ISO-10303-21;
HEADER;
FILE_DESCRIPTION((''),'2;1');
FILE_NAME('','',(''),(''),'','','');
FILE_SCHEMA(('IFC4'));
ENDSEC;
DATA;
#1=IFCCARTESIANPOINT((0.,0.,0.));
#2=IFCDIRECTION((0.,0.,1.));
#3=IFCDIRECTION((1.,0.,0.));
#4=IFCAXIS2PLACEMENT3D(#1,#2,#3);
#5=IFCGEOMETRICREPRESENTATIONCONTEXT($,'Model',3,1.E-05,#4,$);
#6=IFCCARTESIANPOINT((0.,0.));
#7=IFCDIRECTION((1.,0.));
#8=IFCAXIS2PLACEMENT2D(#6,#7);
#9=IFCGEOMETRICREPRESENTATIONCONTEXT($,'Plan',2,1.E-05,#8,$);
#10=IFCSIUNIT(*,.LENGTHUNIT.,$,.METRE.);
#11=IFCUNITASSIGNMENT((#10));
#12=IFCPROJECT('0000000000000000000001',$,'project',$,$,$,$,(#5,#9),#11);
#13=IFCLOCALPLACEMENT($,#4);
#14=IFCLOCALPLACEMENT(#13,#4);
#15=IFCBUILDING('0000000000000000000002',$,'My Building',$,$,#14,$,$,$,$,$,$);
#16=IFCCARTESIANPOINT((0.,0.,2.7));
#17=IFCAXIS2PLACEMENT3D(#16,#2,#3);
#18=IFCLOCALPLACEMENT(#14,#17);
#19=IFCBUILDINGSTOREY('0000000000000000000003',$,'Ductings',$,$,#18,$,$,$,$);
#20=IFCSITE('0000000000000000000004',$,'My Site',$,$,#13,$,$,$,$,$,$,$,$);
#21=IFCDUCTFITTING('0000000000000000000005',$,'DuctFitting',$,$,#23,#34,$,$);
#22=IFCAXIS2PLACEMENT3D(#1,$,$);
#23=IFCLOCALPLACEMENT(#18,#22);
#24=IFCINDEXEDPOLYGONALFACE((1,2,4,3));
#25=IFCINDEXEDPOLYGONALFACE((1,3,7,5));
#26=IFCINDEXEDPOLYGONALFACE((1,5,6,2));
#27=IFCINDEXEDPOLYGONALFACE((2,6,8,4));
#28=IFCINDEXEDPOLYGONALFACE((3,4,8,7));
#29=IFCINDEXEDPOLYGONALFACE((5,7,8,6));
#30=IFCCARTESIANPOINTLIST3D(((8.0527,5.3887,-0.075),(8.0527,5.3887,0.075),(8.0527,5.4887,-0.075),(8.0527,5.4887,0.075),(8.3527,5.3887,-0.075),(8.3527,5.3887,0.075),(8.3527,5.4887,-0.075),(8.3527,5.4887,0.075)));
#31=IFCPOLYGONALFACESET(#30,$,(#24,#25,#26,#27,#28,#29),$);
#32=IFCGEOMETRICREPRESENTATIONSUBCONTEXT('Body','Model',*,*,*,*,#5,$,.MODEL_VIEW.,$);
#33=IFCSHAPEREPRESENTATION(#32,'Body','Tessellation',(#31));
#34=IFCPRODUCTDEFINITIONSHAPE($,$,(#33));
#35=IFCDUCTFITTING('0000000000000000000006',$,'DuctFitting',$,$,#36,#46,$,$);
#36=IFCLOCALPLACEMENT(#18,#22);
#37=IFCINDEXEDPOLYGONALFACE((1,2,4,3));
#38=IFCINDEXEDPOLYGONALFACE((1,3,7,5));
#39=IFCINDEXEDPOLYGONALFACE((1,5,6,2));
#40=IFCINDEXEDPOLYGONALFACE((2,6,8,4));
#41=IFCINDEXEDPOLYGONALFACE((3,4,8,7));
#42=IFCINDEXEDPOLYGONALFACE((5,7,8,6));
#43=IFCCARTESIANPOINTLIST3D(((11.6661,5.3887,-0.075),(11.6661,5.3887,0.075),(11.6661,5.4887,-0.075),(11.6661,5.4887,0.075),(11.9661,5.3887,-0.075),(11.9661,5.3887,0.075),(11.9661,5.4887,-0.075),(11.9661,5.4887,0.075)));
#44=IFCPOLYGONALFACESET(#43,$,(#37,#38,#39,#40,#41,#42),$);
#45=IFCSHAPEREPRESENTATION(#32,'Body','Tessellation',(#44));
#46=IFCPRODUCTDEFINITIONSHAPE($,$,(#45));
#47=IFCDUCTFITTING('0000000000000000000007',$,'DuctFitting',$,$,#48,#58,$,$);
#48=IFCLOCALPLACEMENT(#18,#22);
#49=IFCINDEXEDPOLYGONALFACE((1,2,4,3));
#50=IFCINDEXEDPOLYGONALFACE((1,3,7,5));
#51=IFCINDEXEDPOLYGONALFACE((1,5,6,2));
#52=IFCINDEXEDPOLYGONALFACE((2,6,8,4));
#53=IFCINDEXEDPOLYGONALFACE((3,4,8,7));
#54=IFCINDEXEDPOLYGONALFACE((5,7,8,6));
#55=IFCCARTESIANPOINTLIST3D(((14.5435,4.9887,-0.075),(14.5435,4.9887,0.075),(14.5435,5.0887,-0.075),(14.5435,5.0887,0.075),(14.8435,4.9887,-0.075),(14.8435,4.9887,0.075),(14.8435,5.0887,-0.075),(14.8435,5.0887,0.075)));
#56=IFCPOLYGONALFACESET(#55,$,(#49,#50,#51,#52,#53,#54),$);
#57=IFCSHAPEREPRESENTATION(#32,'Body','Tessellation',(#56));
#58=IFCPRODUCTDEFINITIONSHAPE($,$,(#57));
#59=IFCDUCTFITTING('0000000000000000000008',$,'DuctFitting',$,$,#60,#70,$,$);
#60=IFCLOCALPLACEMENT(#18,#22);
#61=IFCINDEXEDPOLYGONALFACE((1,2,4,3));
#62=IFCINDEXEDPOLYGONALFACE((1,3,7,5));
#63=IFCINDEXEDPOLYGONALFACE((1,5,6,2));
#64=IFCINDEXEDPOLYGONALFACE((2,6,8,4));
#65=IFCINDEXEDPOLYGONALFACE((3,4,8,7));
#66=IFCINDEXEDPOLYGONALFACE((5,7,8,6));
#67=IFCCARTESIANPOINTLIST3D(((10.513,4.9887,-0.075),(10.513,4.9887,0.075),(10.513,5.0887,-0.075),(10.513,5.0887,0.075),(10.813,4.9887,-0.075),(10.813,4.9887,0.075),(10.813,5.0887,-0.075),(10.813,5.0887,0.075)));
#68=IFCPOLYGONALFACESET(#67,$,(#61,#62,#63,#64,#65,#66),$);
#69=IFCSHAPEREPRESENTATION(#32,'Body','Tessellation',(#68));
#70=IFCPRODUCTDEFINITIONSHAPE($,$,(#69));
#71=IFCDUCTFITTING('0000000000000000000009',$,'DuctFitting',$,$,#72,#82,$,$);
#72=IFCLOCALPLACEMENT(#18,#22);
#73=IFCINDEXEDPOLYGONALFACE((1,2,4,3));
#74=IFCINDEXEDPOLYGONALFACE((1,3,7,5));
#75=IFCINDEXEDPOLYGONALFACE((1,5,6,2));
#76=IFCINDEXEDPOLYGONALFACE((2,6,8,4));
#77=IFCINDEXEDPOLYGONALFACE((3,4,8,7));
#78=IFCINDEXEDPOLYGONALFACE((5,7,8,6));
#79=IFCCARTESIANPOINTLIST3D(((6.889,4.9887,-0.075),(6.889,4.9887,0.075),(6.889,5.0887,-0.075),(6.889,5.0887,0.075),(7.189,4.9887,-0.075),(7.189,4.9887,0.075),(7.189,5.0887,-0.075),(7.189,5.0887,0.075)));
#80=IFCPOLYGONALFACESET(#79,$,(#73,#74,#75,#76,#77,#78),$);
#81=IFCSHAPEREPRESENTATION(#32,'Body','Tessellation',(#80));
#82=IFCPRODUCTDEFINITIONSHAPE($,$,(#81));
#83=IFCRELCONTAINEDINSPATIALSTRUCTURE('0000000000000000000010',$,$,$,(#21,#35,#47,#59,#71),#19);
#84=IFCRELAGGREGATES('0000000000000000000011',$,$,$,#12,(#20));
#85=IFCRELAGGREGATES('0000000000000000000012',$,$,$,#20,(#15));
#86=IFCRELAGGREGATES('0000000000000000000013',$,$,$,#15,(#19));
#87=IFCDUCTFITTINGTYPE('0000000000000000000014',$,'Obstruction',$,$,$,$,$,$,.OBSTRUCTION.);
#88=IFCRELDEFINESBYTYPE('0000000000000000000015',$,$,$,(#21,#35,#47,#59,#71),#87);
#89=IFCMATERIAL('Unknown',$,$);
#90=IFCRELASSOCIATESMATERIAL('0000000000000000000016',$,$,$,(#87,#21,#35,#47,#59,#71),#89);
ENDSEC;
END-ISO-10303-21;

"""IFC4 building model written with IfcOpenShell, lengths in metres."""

from ifc_helpers import new_model, si_unit, frame, origin_with_axes, origin_2d_with_axis, place, context, subcontext, project, spatial, rectangle, extrude, material, material_profile, profile_set, profile_usage, type_object, element, save


model = new_model("IFC4")

# Units and contexts
model_context = context("Model", 3, precision=1e-05, world=origin_with_axes())
plan_context = context("Plan", 2, precision=1e-05, world=origin_2d_with_axis())
body_context = subcontext(model_context, "Body", "Model", "MODEL_VIEW")
ifc_project = project(units=[si_unit("LENGTHUNIT", "METRE")], contexts=[model_context, plan_context])

# Site, building, storey
site_placement = place(None, origin_with_axes())
site = spatial("IfcSite", under=ifc_project, at=site_placement, Name="My Site")
building_placement = place(site_placement, origin_with_axes())
building = spatial("IfcBuilding", under=site, at=building_placement, Name="My Building")
storey_placement = place(building_placement, frame((0.0, 0.0, 2.7), z_axis=(0.0, 0.0, 1.0), x_axis=(1.0, 0.0, 0.0)))
storey = spatial("IfcBuildingStorey", under=building, at=storey_placement, Name="Ductings")

# Shared definitions
ifc_material = material(Name="Unknown")

# Duct fittings
ifc_material_profile_1 = material_profile(ifc_material, rectangle(XDim=0.3, YDim=0.15))
ifc_profile_set_1 = profile_set([ifc_material_profile_1])
duct_fitting_type_1 = type_object("IfcDuctFittingType", Name="Obstruction", PredefinedType="OBSTRUCTION", material=ifc_profile_set_1)
ifc_profile_usage_1 = profile_usage(ifc_profile_set_1, cardinal=5)
duct_fitting_1_placement = place(storey_placement, frame((8.2027, 5.3887, 0.0), z_axis=(0.0, 1.0, 0.0), x_axis=(-1.0, 0.0, 0.0)))
element("IfcDuctFitting", 1, at=duct_fitting_1_placement, inside=storey, type_object=duct_fitting_type_1, material=ifc_profile_usage_1, Name="DuctFitting", context=body_context, shape_type="SweptSolid", body=[
    extrude(rectangle(XDim=0.3, YDim=0.15), origin_with_axes(), (0.0, 0.0, 1.0), 0.1),
])
ifc_profile_usage_2 = profile_usage(ifc_profile_set_1, cardinal=5)
duct_fitting_2_placement = place(storey_placement, frame((11.8161, 5.3887, 0.0), z_axis=(0.0, 1.0, 0.0), x_axis=(-1.0, 0.0, 0.0)))
element("IfcDuctFitting", 2, at=duct_fitting_2_placement, inside=storey, type_object=duct_fitting_type_1, material=ifc_profile_usage_2, Name="DuctFitting", context=body_context, shape_type="SweptSolid", body=[
    extrude(rectangle(XDim=0.3, YDim=0.15), origin_with_axes(), (0.0, 0.0, 1.0), 0.1),
])
ifc_profile_usage_3 = profile_usage(ifc_profile_set_1, cardinal=5)
duct_fitting_3_placement = place(storey_placement, frame((14.6935, 5.0887, 0.0), z_axis=(0.0, -1.0, 0.0), x_axis=(1.0, 0.0, 0.0)))
element("IfcDuctFitting", 3, at=duct_fitting_3_placement, inside=storey, type_object=duct_fitting_type_1, material=ifc_profile_usage_3, Name="DuctFitting", context=body_context, shape_type="SweptSolid", body=[
    extrude(rectangle(XDim=0.3, YDim=0.15), origin_with_axes(), (0.0, 0.0, 1.0), 0.1),
])
ifc_profile_usage_4 = profile_usage(ifc_profile_set_1, cardinal=5)
duct_fitting_4_placement = place(storey_placement, frame((10.663, 5.0887, 0.0), z_axis=(0.0, -1.0, 0.0), x_axis=(1.0, 0.0, 0.0)))
element("IfcDuctFitting", 4, at=duct_fitting_4_placement, inside=storey, type_object=duct_fitting_type_1, material=ifc_profile_usage_4, Name="DuctFitting", context=body_context, shape_type="SweptSolid", body=[
    extrude(rectangle(XDim=0.3, YDim=0.15), origin_with_axes(), (0.0, 0.0, 1.0), 0.1),
])
ifc_profile_usage_5 = profile_usage(ifc_profile_set_1, cardinal=5)
duct_fitting_5_placement = place(storey_placement, frame((7.039, 5.0887, 0.0), z_axis=(0.0, -1.0, 0.0), x_axis=(1.0, 0.0, 0.0)))
element("IfcDuctFitting", 5, at=duct_fitting_5_placement, inside=storey, type_object=duct_fitting_type_1, material=ifc_profile_usage_5, Name="DuctFitting", context=body_context, shape_type="SweptSolid", body=[
    extrude(rectangle(XDim=0.3, YDim=0.15), origin_with_axes(), (0.0, 0.0, 1.0), 0.1),
])

save(model, "model.ifc")
